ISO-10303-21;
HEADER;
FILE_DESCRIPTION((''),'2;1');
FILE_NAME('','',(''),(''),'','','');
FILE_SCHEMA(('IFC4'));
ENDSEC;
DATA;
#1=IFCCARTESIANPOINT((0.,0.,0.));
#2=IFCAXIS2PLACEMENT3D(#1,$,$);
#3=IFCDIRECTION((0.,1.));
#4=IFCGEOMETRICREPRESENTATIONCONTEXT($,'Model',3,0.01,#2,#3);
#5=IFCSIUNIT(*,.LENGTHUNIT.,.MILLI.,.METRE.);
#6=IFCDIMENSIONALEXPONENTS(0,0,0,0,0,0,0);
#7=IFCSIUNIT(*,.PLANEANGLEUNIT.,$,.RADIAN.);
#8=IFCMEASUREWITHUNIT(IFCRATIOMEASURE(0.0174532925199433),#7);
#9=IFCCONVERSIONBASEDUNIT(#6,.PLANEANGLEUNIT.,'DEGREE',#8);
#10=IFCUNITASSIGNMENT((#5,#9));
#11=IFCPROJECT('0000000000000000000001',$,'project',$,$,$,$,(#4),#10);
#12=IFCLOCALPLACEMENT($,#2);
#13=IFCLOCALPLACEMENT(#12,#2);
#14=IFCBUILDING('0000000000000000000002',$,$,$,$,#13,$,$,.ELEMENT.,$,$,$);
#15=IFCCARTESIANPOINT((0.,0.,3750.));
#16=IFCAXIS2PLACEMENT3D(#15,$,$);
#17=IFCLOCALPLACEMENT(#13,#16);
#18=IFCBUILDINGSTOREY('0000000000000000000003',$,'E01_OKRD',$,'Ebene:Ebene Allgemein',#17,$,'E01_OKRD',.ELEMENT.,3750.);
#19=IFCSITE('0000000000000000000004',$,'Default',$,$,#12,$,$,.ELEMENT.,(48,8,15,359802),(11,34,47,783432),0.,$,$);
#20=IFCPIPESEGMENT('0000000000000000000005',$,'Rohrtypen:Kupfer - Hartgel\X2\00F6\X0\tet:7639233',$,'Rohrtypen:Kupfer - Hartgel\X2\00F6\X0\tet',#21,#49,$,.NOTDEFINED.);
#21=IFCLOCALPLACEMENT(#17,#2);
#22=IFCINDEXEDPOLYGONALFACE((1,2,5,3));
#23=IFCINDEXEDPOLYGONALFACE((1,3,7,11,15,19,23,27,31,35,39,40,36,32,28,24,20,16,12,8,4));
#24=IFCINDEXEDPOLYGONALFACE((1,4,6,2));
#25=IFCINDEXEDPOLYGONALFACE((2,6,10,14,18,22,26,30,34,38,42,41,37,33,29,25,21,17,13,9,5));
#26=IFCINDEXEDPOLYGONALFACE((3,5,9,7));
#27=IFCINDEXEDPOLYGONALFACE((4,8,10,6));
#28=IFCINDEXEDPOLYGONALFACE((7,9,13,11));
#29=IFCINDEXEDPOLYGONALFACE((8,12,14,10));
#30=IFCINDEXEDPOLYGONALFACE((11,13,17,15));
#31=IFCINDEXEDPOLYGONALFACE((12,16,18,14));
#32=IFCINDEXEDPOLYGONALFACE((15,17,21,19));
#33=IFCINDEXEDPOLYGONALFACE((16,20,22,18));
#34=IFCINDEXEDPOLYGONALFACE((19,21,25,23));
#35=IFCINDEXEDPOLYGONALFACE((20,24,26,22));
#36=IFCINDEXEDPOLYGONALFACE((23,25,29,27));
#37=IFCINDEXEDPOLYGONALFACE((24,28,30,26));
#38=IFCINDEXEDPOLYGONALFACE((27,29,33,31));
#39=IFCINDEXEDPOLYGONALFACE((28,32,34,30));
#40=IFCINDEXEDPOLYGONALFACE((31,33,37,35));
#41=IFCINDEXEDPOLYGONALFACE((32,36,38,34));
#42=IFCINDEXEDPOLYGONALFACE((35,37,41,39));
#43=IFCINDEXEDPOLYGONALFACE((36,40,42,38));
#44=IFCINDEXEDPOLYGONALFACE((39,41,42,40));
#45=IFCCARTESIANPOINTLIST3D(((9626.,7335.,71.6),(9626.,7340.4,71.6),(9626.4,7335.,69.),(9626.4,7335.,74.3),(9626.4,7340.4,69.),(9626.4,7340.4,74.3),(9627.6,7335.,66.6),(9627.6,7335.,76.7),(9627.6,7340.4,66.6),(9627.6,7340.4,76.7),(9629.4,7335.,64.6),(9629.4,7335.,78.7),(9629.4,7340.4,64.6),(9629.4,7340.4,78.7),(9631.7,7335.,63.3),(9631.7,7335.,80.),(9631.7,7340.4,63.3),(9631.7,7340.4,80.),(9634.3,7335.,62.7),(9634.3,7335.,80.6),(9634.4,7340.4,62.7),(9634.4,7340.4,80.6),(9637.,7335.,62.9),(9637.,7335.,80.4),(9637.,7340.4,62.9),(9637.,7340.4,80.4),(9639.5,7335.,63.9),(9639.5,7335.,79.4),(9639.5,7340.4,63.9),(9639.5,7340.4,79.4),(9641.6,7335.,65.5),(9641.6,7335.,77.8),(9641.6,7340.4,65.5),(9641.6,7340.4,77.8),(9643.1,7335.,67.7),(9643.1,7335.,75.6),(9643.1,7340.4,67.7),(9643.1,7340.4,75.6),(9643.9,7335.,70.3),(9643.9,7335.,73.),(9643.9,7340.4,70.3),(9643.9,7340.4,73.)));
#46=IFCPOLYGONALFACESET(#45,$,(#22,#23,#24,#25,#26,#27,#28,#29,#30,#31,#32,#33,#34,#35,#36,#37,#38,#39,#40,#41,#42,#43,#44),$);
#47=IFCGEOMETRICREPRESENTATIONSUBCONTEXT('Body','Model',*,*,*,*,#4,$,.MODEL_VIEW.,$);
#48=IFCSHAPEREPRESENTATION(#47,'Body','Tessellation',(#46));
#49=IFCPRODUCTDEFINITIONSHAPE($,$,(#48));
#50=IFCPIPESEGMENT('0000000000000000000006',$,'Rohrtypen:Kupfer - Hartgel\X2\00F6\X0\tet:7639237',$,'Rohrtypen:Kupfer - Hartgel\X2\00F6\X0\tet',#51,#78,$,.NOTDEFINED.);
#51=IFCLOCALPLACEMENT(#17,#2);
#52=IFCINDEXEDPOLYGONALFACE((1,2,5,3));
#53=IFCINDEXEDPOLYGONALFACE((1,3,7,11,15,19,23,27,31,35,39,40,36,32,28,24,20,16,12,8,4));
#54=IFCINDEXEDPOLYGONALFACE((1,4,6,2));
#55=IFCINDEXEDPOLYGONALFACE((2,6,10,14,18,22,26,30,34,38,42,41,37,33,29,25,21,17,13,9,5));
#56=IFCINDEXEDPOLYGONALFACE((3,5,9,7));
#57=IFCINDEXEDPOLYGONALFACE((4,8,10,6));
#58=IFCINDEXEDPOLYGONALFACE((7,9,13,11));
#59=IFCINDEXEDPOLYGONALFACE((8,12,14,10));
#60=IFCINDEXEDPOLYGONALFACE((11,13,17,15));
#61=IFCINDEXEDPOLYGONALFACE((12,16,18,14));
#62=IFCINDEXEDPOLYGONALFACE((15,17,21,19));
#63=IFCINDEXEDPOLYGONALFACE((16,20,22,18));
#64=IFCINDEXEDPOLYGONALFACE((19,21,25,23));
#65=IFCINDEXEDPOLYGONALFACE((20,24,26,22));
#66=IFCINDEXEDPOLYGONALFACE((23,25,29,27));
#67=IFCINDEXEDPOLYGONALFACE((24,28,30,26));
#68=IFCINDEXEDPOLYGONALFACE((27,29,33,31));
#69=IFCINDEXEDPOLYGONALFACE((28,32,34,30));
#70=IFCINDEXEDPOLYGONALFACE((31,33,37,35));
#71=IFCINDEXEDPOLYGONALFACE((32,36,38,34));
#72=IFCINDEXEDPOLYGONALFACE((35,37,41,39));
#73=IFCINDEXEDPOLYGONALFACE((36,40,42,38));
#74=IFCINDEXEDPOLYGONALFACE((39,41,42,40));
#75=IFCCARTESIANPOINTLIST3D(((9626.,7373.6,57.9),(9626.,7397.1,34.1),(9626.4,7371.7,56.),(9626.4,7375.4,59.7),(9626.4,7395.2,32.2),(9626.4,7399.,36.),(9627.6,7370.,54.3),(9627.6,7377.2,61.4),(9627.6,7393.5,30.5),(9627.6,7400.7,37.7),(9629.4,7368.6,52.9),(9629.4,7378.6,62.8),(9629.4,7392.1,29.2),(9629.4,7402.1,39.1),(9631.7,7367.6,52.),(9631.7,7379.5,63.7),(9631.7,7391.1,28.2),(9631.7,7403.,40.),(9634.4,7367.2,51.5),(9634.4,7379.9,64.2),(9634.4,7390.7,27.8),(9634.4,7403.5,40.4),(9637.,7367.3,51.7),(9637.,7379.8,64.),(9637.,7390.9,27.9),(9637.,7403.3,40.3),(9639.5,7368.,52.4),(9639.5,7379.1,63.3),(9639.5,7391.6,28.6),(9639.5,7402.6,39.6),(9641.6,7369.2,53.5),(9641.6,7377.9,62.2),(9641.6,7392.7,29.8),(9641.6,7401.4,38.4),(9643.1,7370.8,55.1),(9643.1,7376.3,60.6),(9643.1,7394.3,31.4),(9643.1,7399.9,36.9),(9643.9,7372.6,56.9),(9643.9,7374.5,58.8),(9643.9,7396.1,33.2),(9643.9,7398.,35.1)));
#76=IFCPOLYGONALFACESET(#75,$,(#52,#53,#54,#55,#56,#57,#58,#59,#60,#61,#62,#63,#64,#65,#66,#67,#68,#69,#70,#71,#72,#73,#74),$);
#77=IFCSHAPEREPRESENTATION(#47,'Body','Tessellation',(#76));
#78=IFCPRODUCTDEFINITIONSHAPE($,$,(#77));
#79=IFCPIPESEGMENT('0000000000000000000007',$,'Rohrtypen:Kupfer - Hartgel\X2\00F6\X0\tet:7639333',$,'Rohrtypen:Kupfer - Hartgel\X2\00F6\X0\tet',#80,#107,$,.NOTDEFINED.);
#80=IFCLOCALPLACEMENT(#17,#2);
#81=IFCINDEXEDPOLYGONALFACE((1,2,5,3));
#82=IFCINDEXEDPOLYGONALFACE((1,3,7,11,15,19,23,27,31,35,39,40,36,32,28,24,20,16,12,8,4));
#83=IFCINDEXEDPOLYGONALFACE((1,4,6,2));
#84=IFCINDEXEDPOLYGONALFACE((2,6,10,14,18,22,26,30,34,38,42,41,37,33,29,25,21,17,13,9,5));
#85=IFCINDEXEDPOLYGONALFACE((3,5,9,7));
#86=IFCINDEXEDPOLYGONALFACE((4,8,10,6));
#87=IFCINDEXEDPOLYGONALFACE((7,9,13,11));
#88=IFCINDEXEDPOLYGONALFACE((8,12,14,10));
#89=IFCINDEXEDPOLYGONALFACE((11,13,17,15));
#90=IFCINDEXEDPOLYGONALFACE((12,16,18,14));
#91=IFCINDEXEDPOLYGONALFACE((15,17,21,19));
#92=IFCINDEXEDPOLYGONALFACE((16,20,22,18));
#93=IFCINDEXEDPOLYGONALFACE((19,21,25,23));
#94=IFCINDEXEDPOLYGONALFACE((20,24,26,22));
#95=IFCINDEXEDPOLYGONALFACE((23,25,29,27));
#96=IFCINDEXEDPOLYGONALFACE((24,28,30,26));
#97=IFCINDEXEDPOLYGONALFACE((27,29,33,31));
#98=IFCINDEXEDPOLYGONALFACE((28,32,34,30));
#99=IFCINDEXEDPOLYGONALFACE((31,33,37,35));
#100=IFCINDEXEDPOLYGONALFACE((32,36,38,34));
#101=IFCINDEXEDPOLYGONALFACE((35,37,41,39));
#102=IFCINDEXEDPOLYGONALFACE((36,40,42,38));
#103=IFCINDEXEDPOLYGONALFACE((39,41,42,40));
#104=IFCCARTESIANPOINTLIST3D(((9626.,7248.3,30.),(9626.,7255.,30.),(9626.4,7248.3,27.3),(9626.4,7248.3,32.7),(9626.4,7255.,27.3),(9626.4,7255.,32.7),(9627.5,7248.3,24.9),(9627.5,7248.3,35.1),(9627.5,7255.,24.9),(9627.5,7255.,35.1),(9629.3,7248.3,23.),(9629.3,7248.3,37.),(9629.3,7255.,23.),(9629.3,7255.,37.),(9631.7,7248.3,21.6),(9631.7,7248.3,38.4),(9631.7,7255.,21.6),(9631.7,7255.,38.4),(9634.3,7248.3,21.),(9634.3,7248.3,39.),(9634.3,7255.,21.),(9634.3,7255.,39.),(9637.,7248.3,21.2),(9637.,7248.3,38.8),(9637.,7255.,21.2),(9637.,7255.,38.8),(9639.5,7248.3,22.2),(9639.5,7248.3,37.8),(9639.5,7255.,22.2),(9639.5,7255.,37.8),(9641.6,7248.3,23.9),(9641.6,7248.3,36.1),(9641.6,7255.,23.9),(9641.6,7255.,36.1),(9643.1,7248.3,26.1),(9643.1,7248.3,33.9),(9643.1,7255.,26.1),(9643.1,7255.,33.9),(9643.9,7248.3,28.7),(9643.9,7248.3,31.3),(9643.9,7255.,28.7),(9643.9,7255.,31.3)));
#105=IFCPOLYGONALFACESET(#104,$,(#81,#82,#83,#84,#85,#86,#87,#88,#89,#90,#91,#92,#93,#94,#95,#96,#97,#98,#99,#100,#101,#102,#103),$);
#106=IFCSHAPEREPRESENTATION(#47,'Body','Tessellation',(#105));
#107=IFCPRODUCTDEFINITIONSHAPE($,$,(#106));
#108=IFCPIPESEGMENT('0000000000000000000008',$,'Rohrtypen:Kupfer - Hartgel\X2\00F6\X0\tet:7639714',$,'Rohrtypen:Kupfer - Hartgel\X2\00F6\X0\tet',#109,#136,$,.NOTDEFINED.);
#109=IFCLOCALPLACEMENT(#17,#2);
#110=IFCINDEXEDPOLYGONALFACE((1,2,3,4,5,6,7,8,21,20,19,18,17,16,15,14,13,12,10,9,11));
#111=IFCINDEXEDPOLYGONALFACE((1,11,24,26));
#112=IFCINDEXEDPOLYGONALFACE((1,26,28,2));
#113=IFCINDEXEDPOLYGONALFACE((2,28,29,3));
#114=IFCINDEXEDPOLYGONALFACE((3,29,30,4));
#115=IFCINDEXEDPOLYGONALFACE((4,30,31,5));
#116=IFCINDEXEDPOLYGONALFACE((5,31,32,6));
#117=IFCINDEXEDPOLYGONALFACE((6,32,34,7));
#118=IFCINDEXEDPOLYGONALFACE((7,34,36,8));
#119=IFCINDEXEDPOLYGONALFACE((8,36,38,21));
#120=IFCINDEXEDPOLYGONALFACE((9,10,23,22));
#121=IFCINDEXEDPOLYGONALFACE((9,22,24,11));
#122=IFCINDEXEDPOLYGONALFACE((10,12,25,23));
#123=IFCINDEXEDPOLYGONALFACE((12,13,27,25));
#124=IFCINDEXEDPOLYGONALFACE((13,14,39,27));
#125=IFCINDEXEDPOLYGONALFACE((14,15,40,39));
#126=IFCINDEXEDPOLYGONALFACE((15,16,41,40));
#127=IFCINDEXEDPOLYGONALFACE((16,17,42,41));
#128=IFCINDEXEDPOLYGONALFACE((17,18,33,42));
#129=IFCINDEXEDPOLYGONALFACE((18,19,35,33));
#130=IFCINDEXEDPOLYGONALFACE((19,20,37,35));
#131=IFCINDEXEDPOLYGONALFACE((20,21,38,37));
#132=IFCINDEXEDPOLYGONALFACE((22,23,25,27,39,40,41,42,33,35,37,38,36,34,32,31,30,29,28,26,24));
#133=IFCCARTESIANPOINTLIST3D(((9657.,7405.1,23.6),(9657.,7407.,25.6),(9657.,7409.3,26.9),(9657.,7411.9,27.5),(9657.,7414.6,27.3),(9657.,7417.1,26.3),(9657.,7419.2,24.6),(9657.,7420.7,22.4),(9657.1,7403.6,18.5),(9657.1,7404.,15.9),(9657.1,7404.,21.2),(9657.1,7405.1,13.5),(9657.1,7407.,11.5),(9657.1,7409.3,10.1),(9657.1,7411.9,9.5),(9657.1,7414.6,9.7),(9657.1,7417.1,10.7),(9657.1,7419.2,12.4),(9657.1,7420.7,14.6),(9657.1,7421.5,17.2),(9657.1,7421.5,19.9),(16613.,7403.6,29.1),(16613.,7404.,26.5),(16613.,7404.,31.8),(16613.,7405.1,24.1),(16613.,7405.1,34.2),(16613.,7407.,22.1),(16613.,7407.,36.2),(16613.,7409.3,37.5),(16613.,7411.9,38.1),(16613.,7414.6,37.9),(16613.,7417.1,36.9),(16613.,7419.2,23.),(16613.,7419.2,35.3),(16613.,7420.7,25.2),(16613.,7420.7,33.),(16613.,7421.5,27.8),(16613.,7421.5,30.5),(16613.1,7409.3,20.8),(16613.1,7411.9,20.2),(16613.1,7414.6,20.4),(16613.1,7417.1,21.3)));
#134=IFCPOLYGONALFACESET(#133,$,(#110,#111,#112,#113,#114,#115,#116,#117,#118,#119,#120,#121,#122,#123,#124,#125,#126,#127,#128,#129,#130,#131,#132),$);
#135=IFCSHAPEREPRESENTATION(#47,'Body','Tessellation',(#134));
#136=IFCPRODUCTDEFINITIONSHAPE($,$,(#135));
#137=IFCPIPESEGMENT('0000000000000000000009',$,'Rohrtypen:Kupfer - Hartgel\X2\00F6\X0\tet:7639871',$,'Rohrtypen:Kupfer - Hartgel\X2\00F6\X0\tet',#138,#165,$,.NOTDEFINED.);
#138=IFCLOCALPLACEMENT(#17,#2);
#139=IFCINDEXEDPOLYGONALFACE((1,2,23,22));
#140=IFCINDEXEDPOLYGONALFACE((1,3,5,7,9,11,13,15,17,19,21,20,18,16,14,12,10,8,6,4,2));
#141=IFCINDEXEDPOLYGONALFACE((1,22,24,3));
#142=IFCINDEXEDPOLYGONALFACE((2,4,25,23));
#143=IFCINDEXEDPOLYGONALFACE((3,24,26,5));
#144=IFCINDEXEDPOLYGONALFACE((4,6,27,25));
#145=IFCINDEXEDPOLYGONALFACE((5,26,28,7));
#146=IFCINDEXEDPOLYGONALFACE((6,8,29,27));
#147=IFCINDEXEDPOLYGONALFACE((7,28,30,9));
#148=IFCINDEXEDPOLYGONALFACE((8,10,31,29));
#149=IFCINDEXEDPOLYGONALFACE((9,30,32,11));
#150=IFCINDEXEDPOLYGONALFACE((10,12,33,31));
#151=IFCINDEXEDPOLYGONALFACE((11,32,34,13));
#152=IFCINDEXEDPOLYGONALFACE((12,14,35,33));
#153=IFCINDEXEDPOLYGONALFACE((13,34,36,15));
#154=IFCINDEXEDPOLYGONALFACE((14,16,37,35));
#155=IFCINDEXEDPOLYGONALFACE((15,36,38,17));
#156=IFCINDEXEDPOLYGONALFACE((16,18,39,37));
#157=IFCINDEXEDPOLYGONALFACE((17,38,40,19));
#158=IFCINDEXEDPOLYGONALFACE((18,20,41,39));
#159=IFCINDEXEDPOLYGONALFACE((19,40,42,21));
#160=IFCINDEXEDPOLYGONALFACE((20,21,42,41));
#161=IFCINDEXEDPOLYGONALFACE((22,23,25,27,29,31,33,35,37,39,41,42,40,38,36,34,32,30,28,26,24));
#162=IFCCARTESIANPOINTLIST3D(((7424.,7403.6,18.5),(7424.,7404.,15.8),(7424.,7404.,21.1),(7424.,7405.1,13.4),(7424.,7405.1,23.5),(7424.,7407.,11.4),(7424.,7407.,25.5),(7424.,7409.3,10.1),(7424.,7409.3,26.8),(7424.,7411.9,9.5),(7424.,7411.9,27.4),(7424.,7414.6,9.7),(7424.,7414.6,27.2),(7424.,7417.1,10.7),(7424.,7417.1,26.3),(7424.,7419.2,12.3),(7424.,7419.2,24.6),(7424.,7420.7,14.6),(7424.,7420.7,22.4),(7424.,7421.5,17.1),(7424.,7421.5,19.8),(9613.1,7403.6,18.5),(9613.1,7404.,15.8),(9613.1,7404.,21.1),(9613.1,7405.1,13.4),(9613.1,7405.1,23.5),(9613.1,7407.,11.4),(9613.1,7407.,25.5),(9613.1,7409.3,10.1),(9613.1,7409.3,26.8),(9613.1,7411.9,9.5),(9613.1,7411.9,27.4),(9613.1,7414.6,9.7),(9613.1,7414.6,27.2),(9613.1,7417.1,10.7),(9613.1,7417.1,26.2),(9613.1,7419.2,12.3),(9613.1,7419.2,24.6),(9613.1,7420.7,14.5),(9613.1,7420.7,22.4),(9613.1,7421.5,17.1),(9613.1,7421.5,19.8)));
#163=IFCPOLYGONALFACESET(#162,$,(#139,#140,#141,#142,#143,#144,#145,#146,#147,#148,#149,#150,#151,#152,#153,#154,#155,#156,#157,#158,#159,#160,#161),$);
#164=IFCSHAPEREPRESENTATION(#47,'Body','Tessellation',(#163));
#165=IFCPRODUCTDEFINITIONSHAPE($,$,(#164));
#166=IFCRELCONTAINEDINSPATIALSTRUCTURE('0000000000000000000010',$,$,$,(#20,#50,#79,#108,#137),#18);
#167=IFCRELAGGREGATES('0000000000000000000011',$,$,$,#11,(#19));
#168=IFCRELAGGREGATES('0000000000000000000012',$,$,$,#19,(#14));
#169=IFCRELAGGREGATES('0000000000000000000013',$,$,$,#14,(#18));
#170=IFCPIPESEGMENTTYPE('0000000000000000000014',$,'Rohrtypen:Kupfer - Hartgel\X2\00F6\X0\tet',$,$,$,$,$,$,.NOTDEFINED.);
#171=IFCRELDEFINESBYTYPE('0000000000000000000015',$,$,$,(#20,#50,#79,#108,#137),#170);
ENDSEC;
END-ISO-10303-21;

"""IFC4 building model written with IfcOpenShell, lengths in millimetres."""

from ifc_helpers import new_model, entity, si_unit, converted_unit, direction, frame, frame_2d, origin, origin_2d_with_axis, place, context, subcontext, project, spatial, circle, extrude, type_object, element, save


model = new_model("IFC4")

# Units and contexts
model_context = context("Model", 3, precision=0.01, world=origin(), true_north=direction((0.0, 1.0)))
body_context = subcontext(model_context, "Body", "Model", "MODEL_VIEW")
ifc_project = project(units=[si_unit("LENGTHUNIT", "METRE", prefix="MILLI"), converted_unit("PLANEANGLEUNIT", "DEGREE", entity("IfcRatioMeasure", 0.0174532925199433), si_unit("PLANEANGLEUNIT", "RADIAN"), dimensions=[0, 0, 0, 0, 0, 0, 0])], contexts=[model_context])

# Site, building, storey
site_placement = place(None, origin())
site = spatial("IfcSite", under=ifc_project, at=site_placement, Name="Default", CompositionType="ELEMENT", RefLatitude=(48, 8, 15, 359802), RefLongitude=(11, 34, 47, 783432), RefElevation=0.0)
building_placement = place(site_placement, origin())
building = spatial("IfcBuilding", under=site, at=building_placement, CompositionType="ELEMENT")
storey_placement = place(building_placement, frame((0.0, 0.0, 3750.0)))
storey = spatial("IfcBuildingStorey", under=building, at=storey_placement, Name="E01_OKRD", ObjectType="Ebene:Ebene Allgemein", LongName="E01_OKRD", CompositionType="ELEMENT", Elevation=3750.0)

# Pipe segments
pipe_segment_type = type_object("IfcPipeSegmentType", Name="Rohrtypen:Kupfer - Hartgelötet", PredefinedType="NOTDEFINED")
pipe_segment_1_placement = place(storey_placement, frame((9624.4, 7335.0, 61.1)))
element("IfcPipeSegment", 1, at=pipe_segment_1_placement, inside=storey, type_object=pipe_segment_type, Name="Rohrtypen:Kupfer - Hartgelötet:7639233", ObjectType="Rohrtypen:Kupfer - Hartgelötet", PredefinedType="NOTDEFINED", context=body_context, shape_type="SweptSolid", body=[
    extrude(circle(Radius=9.0, at=origin_2d_with_axis()), frame((10.6, 0.0, 10.6), z_axis=(0.003269, 0.999995, 0.0), x_axis=(-0.999995, 0.003269, -0.000001)), (0.0, 0.0, 1.0), 5.4),
])
pipe_segment_2_placement = place(storey_placement, frame((9624.4, 7365.6, 26.2)))
element("IfcPipeSegment", 2, at=pipe_segment_2_placement, inside=storey, type_object=pipe_segment_type, Name="Rohrtypen:Kupfer - Hartgelötet:7639237", ObjectType="Rohrtypen:Kupfer - Hartgelötet", PredefinedType="NOTDEFINED", context=body_context, shape_type="SweptSolid", body=[
    extrude(circle(Radius=9.0, at=origin_2d_with_axis()), frame((10.6, 31.5, 7.9), z_axis=(0.0, -0.70394, 0.71026), x_axis=(-1.0, 0.0, 0.0)), (0.0, 0.0, 1.0), 33.4),
])
pipe_segment_3_placement = place(storey_placement, frame((9624.4, 7248.3, 19.4)))
element("IfcPipeSegment", 3, at=pipe_segment_3_placement, inside=storey, type_object=pipe_segment_type, Name="Rohrtypen:Kupfer - Hartgelötet:7639333", ObjectType="Rohrtypen:Kupfer - Hartgelötet", PredefinedType="NOTDEFINED", context=body_context, shape_type="SweptSolid", body=[
    extrude(circle(Radius=9.0, at=origin_2d_with_axis()), frame((10.6, 0.0, 10.6), z_axis=(0.000018, 1.0, 0.0), x_axis=(-1.0, 0.000018, 0.0)), (0.0, 0.0, 1.0), 6.6),
])
pipe_segment_4_placement = place(storey_placement, frame((9657.0, 7402.0, 7.9)))
element("IfcPipeSegment", 4, at=pipe_segment_4_placement, inside=storey, type_object=pipe_segment_type, Name="Rohrtypen:Kupfer - Hartgelötet:7639714", ObjectType="Rohrtypen:Kupfer - Hartgelötet", PredefinedType="NOTDEFINED", context=body_context, shape_type="SweptSolid", body=[
    extrude(circle(Radius=9.0, at=origin_2d_with_axis()), frame((0.0, 10.6, 10.6), z_axis=(0.999999, 0.0, 0.001525), x_axis=(0.0, -1.0, 0.0)), (0.0, 0.0, 1.0), 6956.0),
])
pipe_segment_5_placement = place(storey_placement, frame((7424.0, 7402.0, 7.9)))
element("IfcPipeSegment", 5, at=pipe_segment_5_placement, inside=storey, type_object=pipe_segment_type, Name="Rohrtypen:Kupfer - Hartgelötet:7639871", ObjectType="Rohrtypen:Kupfer - Hartgelötet", PredefinedType="NOTDEFINED", context=body_context, shape_type="SweptSolid", body=[
    extrude(circle(Radius=9.0, at=frame_2d((0.0, 0.0), x_axis=(1.0, 0.0))), frame((0.0, 10.6, 10.6), z_axis=(1.0, 0.0, -0.000002), x_axis=(0.0, -1.0, 0.0)), (0.0, 0.0, 1.0), 2189.1),
])

save(model, "model.ifc")
